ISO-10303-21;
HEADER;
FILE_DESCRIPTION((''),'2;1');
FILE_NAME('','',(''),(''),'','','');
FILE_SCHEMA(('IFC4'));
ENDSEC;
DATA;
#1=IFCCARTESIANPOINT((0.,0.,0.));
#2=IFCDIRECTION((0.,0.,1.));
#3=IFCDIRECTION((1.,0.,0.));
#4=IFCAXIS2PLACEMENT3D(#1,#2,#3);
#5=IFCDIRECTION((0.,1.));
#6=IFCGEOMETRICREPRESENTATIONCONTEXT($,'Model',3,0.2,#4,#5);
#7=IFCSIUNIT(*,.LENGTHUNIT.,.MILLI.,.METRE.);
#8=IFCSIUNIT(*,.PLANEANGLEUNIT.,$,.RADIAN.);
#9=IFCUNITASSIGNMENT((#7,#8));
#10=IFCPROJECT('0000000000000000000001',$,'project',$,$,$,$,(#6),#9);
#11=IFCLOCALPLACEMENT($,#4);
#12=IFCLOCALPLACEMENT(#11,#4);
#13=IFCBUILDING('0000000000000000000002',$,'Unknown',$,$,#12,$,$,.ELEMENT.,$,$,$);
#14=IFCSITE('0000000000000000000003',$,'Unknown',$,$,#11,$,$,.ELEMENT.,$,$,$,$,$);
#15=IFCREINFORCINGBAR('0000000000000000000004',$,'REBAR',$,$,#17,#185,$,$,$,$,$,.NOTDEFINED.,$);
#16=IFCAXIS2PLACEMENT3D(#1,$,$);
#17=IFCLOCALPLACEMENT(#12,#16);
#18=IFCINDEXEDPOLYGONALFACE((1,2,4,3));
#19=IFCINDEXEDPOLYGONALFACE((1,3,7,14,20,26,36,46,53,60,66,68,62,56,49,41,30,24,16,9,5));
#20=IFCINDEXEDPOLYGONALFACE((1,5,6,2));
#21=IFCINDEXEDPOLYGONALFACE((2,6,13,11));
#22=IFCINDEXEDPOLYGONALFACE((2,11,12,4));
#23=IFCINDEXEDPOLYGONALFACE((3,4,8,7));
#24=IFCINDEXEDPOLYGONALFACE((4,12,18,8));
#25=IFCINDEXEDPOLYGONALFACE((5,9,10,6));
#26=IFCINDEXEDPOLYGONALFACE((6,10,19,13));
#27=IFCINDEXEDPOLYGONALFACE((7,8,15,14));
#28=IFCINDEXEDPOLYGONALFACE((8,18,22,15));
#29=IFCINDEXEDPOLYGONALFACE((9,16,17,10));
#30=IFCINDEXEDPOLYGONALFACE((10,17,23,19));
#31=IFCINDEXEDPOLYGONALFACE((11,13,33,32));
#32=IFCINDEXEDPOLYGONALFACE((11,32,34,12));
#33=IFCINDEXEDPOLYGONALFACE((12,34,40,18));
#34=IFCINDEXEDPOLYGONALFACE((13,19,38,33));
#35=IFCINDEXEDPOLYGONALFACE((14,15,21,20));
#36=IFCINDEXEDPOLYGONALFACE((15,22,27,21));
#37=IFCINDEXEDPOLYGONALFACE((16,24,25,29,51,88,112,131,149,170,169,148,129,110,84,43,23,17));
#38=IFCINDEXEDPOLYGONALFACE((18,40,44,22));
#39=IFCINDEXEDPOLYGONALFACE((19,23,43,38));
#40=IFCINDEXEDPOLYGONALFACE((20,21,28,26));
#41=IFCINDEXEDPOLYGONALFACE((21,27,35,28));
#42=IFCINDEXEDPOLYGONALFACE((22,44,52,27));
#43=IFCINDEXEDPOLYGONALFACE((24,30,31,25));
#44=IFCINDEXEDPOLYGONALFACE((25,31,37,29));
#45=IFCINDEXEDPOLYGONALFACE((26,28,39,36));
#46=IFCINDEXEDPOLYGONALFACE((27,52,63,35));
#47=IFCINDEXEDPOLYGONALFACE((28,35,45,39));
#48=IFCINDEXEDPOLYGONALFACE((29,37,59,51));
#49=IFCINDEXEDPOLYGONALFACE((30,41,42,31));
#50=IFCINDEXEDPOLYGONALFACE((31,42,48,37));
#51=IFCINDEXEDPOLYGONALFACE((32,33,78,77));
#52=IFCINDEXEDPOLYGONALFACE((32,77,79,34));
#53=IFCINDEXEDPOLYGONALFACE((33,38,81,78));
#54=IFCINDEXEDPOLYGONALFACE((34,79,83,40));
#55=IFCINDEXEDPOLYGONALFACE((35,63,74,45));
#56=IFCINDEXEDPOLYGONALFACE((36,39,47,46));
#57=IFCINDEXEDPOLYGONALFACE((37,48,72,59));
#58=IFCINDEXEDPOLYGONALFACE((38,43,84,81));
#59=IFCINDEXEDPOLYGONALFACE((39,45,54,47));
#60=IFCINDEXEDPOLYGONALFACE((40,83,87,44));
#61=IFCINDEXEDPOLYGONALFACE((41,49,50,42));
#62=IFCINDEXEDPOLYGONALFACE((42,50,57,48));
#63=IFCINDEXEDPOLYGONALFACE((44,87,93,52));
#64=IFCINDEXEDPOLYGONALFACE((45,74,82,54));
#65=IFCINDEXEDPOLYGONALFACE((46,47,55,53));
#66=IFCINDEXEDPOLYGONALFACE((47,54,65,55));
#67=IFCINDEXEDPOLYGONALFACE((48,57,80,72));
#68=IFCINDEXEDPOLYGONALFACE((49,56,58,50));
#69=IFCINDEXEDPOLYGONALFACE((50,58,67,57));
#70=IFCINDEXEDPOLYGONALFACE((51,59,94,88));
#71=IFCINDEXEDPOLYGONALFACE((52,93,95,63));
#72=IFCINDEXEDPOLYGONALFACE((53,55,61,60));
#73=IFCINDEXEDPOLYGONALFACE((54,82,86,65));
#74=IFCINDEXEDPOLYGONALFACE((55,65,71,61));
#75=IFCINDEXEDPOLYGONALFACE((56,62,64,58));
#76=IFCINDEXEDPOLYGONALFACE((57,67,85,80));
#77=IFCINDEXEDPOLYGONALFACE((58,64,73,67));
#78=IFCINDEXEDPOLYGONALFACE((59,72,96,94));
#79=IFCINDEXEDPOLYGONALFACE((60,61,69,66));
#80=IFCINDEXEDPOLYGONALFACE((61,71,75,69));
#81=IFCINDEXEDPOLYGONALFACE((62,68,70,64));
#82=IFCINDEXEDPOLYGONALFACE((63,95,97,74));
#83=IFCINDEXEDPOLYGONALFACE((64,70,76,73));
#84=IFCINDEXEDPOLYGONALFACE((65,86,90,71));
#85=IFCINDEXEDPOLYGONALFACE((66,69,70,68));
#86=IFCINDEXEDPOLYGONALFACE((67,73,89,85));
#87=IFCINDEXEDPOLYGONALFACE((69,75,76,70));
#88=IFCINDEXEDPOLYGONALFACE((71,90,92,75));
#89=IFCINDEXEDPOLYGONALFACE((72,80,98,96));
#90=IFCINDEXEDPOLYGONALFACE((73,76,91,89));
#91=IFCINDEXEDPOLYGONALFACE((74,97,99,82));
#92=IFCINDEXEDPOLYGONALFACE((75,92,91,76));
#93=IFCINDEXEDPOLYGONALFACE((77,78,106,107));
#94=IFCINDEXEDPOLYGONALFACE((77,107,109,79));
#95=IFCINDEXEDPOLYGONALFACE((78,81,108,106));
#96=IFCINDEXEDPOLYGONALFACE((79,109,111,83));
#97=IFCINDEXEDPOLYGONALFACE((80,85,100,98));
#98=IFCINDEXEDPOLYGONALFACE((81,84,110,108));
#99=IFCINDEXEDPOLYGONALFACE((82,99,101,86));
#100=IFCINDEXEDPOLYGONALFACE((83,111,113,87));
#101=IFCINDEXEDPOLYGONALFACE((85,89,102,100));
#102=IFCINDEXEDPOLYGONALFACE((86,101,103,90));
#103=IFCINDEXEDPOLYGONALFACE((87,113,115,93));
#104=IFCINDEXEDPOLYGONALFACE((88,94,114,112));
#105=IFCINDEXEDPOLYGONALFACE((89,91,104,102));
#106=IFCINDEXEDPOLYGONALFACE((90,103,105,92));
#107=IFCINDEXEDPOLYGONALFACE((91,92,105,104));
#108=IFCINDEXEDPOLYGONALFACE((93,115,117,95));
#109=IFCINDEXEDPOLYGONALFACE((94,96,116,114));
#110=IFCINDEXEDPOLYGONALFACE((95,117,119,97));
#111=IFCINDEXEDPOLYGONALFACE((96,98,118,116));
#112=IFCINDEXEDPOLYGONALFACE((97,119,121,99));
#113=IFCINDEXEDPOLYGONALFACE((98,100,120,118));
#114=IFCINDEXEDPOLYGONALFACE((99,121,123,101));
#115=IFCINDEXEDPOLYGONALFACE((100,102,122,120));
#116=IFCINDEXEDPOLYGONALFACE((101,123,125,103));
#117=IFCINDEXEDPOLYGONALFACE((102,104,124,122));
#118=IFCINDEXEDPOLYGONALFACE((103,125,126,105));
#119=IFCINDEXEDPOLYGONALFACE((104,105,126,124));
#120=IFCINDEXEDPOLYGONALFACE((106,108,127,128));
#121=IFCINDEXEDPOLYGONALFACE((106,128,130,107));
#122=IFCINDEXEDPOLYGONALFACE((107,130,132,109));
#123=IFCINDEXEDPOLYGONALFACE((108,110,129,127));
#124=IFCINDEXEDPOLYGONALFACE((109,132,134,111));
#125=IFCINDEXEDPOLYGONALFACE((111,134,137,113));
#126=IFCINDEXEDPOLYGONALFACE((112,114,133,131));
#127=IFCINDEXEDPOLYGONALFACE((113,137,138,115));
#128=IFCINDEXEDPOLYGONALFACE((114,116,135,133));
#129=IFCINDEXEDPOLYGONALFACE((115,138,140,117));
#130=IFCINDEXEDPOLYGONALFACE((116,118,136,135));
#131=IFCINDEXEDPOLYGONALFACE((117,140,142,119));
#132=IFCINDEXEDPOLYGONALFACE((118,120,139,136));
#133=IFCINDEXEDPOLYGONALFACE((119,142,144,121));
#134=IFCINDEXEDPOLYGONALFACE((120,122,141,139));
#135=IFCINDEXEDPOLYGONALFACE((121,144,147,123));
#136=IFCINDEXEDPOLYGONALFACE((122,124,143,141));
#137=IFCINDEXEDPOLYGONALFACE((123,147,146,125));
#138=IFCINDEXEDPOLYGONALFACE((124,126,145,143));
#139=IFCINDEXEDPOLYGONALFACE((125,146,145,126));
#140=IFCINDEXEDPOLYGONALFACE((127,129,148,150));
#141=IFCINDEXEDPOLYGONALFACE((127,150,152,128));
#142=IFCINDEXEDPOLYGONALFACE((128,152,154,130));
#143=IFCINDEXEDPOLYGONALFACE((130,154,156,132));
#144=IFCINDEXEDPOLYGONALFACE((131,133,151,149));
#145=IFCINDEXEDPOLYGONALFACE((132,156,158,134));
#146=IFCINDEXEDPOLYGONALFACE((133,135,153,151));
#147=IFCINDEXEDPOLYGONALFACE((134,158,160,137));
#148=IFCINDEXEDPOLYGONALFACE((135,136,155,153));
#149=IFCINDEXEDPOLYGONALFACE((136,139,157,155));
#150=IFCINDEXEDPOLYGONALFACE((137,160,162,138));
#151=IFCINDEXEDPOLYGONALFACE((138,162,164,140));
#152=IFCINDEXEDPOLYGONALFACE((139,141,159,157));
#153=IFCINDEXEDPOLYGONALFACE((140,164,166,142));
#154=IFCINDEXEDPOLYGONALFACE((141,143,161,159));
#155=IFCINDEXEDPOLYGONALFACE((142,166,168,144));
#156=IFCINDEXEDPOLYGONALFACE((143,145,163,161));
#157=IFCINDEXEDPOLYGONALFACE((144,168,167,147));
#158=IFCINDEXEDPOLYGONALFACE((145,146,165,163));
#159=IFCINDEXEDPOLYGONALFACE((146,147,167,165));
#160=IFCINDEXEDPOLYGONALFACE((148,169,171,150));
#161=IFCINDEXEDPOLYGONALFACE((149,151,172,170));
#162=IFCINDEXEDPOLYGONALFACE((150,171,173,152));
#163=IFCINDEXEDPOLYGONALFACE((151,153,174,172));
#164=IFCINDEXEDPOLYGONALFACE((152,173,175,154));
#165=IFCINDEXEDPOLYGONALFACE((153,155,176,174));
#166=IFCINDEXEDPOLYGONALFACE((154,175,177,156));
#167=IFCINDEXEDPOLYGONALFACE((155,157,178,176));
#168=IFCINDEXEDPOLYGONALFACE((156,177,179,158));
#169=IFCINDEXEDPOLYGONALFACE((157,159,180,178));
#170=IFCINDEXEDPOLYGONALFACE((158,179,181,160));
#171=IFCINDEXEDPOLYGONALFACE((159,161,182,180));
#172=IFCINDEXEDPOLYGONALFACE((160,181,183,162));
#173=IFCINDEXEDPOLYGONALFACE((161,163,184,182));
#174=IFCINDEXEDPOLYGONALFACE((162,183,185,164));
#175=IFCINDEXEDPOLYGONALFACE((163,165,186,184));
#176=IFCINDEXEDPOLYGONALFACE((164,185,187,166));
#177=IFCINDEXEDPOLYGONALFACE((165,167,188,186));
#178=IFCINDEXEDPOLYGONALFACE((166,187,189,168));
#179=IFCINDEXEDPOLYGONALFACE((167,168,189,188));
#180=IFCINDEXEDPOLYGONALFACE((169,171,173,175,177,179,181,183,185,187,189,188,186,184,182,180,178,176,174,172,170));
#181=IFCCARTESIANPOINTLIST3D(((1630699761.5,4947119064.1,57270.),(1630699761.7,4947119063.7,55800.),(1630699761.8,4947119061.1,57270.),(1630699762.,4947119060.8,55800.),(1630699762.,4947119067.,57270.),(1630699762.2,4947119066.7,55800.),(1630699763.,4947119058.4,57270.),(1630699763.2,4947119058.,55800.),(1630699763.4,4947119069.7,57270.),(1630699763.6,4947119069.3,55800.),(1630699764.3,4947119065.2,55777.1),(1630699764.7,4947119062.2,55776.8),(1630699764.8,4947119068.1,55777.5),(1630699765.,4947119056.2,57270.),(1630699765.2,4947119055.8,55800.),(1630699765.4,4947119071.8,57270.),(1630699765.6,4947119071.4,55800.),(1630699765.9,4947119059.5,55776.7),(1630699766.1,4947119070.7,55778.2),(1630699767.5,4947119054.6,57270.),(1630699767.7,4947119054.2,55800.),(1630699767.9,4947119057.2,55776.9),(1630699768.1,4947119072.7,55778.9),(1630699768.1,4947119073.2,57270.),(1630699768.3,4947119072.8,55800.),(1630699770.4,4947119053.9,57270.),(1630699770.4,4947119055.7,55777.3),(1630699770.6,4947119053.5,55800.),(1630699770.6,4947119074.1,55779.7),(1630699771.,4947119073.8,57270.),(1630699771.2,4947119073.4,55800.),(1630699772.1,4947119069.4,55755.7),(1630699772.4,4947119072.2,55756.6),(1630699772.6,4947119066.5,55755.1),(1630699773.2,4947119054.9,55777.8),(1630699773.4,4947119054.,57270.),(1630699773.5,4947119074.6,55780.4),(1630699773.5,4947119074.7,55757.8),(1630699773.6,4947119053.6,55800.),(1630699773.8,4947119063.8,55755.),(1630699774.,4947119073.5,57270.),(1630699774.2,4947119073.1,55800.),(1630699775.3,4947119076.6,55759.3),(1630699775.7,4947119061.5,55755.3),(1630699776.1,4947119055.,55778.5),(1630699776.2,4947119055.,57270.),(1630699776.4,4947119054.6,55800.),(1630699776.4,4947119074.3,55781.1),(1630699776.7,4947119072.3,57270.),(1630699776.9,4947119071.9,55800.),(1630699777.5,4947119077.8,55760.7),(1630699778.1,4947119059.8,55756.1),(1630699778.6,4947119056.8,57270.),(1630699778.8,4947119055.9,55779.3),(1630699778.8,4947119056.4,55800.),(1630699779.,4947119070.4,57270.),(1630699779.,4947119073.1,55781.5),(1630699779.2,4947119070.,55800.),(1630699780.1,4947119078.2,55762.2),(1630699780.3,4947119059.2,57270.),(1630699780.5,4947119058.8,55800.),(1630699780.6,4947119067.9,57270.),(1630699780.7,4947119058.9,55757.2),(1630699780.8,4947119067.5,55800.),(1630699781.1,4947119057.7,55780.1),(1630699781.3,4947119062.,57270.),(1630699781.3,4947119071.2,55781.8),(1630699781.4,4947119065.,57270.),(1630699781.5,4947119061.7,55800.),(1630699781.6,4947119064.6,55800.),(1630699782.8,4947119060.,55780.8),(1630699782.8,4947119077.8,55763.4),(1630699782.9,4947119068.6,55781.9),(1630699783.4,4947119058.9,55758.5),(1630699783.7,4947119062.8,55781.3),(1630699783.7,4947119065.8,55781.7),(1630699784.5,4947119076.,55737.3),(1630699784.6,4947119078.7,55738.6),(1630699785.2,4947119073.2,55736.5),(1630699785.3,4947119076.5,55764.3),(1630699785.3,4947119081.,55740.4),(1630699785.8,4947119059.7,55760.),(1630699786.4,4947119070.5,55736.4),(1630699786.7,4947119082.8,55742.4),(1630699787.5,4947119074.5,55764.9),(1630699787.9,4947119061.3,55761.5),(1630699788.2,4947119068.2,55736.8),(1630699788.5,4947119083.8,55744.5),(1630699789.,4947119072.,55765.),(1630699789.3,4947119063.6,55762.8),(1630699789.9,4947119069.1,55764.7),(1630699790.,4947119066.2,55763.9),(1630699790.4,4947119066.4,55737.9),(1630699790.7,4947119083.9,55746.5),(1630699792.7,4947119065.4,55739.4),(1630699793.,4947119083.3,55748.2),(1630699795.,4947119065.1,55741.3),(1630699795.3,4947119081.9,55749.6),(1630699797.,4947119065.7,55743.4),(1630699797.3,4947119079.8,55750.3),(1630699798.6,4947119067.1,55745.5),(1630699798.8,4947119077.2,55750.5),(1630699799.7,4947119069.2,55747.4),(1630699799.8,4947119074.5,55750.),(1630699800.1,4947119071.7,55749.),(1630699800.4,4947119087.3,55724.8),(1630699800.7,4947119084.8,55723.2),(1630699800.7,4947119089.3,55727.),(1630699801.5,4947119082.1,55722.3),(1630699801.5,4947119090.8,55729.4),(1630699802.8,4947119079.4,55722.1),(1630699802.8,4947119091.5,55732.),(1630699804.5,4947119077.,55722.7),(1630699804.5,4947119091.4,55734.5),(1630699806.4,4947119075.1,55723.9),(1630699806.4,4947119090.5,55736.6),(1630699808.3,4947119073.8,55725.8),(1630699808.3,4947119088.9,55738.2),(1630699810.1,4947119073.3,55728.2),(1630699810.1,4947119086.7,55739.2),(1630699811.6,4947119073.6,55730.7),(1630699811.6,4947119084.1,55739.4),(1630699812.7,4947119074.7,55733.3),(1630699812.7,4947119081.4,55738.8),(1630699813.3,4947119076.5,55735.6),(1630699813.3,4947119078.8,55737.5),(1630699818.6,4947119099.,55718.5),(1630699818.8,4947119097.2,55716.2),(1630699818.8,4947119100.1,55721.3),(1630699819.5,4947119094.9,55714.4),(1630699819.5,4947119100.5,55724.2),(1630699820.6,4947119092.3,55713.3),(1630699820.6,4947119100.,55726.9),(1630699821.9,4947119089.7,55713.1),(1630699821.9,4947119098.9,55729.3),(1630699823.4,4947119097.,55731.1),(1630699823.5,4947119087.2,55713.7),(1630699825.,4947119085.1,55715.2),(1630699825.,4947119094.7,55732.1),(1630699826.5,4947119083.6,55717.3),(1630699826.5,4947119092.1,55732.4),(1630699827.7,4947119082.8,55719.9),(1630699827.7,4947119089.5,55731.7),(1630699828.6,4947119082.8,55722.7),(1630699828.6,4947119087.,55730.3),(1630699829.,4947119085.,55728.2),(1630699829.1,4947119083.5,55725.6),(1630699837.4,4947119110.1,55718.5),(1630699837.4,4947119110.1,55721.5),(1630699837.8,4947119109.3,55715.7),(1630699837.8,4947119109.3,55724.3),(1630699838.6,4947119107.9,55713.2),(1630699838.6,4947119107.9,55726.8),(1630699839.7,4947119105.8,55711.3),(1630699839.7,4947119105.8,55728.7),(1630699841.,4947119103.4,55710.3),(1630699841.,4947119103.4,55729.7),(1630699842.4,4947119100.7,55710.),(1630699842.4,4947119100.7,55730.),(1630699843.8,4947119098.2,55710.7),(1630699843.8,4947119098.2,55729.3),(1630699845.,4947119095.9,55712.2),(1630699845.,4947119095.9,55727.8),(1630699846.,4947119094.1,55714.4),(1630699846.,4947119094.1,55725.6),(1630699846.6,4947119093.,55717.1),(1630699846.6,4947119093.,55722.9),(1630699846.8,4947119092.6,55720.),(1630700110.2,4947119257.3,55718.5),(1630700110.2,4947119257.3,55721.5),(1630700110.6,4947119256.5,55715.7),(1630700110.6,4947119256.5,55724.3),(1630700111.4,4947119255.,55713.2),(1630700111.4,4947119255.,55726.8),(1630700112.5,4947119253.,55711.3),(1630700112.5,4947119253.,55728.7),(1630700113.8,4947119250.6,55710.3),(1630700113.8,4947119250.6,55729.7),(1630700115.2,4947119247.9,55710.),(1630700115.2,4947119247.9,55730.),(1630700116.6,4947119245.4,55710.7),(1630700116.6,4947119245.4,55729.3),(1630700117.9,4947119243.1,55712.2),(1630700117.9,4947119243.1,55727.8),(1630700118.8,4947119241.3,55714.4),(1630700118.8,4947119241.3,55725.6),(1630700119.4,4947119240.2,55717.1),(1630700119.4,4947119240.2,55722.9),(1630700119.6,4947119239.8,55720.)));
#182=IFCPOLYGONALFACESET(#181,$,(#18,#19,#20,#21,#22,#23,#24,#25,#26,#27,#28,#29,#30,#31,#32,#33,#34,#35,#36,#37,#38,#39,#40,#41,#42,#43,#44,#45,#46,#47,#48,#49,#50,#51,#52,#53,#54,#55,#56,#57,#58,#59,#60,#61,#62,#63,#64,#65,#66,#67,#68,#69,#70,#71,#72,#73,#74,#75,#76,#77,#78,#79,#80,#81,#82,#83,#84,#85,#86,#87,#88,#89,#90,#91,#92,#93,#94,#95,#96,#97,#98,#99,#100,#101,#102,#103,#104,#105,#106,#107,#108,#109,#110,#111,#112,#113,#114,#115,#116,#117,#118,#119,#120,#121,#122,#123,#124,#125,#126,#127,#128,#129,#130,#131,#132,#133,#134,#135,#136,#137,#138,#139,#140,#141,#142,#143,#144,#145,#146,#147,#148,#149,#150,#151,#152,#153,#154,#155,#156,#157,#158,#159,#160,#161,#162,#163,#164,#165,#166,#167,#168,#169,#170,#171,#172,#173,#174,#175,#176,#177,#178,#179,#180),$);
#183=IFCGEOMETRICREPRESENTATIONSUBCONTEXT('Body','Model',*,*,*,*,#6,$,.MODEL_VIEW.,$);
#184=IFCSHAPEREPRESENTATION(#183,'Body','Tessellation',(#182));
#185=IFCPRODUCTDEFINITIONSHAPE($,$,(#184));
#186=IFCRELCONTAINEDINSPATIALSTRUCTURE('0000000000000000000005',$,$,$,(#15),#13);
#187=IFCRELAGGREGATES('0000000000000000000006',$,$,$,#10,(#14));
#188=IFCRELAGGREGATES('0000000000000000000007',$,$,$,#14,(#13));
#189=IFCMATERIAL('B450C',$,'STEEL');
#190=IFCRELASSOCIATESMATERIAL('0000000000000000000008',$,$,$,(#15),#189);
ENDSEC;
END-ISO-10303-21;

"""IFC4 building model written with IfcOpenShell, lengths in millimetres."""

from ifc_helpers import new_model, entity, si_unit, direction, frame, origin_with_axes, place, context, subcontext, project, spatial, material, element, save


model = new_model("IFC4")

# Units and contexts
model_context = context("Model", 3, precision=0.2, world=origin_with_axes(), true_north=direction((0.0, 1.0)))
body_context = subcontext(model_context, "Body", "Model", "MODEL_VIEW")
ifc_project = project(units=[si_unit("LENGTHUNIT", "METRE", prefix="MILLI"), si_unit("PLANEANGLEUNIT", "RADIAN")], contexts=[model_context])

# Site, building
site_placement = place(None, origin_with_axes())
site = spatial("IfcSite", under=ifc_project, at=site_placement, Name="Unknown", CompositionType="ELEMENT")
building_placement = place(site_placement, origin_with_axes())
building = spatial("IfcBuilding", under=site, at=building_placement, Name="Unknown", CompositionType="ELEMENT")

# Reinforcing bar
ifc_material = material(Name="B450C", Category="STEEL")
reinforcing_bar_1_placement = place(building_placement, frame((1630699703.9, 4947119083.7, 55670.0), z_axis=(0.475117, -0.879922, 0.0), x_axis=(0.0, 0.0, 1.0)))
element("IfcReinforcingBar", 1, at=reinforcing_bar_1_placement, inside=building, material=ifc_material, Name="REBAR", PredefinedType="NOTDEFINED", context=body_context, shape_type="AdvancedSweptSolid", body=[
    entity("IfcSweptDiskSolid", entity("IfcIndexedPolyCurve", entity("IfcCartesianPointList3D", [[50.0, -440.0, 50.1], [50.0, -130.0, 50.0], [73.4, -73.4, 50.0], [130.0, -50.0, 50.0], [1600.0, -50.0, 49.6]]), [entity("IfcLineIndex", [1, 2]), entity("IfcArcIndex", [2, 3, 4]), entity("IfcLineIndex", [4, 5])]), 10.0),
])

save(model, "model.ifc")
